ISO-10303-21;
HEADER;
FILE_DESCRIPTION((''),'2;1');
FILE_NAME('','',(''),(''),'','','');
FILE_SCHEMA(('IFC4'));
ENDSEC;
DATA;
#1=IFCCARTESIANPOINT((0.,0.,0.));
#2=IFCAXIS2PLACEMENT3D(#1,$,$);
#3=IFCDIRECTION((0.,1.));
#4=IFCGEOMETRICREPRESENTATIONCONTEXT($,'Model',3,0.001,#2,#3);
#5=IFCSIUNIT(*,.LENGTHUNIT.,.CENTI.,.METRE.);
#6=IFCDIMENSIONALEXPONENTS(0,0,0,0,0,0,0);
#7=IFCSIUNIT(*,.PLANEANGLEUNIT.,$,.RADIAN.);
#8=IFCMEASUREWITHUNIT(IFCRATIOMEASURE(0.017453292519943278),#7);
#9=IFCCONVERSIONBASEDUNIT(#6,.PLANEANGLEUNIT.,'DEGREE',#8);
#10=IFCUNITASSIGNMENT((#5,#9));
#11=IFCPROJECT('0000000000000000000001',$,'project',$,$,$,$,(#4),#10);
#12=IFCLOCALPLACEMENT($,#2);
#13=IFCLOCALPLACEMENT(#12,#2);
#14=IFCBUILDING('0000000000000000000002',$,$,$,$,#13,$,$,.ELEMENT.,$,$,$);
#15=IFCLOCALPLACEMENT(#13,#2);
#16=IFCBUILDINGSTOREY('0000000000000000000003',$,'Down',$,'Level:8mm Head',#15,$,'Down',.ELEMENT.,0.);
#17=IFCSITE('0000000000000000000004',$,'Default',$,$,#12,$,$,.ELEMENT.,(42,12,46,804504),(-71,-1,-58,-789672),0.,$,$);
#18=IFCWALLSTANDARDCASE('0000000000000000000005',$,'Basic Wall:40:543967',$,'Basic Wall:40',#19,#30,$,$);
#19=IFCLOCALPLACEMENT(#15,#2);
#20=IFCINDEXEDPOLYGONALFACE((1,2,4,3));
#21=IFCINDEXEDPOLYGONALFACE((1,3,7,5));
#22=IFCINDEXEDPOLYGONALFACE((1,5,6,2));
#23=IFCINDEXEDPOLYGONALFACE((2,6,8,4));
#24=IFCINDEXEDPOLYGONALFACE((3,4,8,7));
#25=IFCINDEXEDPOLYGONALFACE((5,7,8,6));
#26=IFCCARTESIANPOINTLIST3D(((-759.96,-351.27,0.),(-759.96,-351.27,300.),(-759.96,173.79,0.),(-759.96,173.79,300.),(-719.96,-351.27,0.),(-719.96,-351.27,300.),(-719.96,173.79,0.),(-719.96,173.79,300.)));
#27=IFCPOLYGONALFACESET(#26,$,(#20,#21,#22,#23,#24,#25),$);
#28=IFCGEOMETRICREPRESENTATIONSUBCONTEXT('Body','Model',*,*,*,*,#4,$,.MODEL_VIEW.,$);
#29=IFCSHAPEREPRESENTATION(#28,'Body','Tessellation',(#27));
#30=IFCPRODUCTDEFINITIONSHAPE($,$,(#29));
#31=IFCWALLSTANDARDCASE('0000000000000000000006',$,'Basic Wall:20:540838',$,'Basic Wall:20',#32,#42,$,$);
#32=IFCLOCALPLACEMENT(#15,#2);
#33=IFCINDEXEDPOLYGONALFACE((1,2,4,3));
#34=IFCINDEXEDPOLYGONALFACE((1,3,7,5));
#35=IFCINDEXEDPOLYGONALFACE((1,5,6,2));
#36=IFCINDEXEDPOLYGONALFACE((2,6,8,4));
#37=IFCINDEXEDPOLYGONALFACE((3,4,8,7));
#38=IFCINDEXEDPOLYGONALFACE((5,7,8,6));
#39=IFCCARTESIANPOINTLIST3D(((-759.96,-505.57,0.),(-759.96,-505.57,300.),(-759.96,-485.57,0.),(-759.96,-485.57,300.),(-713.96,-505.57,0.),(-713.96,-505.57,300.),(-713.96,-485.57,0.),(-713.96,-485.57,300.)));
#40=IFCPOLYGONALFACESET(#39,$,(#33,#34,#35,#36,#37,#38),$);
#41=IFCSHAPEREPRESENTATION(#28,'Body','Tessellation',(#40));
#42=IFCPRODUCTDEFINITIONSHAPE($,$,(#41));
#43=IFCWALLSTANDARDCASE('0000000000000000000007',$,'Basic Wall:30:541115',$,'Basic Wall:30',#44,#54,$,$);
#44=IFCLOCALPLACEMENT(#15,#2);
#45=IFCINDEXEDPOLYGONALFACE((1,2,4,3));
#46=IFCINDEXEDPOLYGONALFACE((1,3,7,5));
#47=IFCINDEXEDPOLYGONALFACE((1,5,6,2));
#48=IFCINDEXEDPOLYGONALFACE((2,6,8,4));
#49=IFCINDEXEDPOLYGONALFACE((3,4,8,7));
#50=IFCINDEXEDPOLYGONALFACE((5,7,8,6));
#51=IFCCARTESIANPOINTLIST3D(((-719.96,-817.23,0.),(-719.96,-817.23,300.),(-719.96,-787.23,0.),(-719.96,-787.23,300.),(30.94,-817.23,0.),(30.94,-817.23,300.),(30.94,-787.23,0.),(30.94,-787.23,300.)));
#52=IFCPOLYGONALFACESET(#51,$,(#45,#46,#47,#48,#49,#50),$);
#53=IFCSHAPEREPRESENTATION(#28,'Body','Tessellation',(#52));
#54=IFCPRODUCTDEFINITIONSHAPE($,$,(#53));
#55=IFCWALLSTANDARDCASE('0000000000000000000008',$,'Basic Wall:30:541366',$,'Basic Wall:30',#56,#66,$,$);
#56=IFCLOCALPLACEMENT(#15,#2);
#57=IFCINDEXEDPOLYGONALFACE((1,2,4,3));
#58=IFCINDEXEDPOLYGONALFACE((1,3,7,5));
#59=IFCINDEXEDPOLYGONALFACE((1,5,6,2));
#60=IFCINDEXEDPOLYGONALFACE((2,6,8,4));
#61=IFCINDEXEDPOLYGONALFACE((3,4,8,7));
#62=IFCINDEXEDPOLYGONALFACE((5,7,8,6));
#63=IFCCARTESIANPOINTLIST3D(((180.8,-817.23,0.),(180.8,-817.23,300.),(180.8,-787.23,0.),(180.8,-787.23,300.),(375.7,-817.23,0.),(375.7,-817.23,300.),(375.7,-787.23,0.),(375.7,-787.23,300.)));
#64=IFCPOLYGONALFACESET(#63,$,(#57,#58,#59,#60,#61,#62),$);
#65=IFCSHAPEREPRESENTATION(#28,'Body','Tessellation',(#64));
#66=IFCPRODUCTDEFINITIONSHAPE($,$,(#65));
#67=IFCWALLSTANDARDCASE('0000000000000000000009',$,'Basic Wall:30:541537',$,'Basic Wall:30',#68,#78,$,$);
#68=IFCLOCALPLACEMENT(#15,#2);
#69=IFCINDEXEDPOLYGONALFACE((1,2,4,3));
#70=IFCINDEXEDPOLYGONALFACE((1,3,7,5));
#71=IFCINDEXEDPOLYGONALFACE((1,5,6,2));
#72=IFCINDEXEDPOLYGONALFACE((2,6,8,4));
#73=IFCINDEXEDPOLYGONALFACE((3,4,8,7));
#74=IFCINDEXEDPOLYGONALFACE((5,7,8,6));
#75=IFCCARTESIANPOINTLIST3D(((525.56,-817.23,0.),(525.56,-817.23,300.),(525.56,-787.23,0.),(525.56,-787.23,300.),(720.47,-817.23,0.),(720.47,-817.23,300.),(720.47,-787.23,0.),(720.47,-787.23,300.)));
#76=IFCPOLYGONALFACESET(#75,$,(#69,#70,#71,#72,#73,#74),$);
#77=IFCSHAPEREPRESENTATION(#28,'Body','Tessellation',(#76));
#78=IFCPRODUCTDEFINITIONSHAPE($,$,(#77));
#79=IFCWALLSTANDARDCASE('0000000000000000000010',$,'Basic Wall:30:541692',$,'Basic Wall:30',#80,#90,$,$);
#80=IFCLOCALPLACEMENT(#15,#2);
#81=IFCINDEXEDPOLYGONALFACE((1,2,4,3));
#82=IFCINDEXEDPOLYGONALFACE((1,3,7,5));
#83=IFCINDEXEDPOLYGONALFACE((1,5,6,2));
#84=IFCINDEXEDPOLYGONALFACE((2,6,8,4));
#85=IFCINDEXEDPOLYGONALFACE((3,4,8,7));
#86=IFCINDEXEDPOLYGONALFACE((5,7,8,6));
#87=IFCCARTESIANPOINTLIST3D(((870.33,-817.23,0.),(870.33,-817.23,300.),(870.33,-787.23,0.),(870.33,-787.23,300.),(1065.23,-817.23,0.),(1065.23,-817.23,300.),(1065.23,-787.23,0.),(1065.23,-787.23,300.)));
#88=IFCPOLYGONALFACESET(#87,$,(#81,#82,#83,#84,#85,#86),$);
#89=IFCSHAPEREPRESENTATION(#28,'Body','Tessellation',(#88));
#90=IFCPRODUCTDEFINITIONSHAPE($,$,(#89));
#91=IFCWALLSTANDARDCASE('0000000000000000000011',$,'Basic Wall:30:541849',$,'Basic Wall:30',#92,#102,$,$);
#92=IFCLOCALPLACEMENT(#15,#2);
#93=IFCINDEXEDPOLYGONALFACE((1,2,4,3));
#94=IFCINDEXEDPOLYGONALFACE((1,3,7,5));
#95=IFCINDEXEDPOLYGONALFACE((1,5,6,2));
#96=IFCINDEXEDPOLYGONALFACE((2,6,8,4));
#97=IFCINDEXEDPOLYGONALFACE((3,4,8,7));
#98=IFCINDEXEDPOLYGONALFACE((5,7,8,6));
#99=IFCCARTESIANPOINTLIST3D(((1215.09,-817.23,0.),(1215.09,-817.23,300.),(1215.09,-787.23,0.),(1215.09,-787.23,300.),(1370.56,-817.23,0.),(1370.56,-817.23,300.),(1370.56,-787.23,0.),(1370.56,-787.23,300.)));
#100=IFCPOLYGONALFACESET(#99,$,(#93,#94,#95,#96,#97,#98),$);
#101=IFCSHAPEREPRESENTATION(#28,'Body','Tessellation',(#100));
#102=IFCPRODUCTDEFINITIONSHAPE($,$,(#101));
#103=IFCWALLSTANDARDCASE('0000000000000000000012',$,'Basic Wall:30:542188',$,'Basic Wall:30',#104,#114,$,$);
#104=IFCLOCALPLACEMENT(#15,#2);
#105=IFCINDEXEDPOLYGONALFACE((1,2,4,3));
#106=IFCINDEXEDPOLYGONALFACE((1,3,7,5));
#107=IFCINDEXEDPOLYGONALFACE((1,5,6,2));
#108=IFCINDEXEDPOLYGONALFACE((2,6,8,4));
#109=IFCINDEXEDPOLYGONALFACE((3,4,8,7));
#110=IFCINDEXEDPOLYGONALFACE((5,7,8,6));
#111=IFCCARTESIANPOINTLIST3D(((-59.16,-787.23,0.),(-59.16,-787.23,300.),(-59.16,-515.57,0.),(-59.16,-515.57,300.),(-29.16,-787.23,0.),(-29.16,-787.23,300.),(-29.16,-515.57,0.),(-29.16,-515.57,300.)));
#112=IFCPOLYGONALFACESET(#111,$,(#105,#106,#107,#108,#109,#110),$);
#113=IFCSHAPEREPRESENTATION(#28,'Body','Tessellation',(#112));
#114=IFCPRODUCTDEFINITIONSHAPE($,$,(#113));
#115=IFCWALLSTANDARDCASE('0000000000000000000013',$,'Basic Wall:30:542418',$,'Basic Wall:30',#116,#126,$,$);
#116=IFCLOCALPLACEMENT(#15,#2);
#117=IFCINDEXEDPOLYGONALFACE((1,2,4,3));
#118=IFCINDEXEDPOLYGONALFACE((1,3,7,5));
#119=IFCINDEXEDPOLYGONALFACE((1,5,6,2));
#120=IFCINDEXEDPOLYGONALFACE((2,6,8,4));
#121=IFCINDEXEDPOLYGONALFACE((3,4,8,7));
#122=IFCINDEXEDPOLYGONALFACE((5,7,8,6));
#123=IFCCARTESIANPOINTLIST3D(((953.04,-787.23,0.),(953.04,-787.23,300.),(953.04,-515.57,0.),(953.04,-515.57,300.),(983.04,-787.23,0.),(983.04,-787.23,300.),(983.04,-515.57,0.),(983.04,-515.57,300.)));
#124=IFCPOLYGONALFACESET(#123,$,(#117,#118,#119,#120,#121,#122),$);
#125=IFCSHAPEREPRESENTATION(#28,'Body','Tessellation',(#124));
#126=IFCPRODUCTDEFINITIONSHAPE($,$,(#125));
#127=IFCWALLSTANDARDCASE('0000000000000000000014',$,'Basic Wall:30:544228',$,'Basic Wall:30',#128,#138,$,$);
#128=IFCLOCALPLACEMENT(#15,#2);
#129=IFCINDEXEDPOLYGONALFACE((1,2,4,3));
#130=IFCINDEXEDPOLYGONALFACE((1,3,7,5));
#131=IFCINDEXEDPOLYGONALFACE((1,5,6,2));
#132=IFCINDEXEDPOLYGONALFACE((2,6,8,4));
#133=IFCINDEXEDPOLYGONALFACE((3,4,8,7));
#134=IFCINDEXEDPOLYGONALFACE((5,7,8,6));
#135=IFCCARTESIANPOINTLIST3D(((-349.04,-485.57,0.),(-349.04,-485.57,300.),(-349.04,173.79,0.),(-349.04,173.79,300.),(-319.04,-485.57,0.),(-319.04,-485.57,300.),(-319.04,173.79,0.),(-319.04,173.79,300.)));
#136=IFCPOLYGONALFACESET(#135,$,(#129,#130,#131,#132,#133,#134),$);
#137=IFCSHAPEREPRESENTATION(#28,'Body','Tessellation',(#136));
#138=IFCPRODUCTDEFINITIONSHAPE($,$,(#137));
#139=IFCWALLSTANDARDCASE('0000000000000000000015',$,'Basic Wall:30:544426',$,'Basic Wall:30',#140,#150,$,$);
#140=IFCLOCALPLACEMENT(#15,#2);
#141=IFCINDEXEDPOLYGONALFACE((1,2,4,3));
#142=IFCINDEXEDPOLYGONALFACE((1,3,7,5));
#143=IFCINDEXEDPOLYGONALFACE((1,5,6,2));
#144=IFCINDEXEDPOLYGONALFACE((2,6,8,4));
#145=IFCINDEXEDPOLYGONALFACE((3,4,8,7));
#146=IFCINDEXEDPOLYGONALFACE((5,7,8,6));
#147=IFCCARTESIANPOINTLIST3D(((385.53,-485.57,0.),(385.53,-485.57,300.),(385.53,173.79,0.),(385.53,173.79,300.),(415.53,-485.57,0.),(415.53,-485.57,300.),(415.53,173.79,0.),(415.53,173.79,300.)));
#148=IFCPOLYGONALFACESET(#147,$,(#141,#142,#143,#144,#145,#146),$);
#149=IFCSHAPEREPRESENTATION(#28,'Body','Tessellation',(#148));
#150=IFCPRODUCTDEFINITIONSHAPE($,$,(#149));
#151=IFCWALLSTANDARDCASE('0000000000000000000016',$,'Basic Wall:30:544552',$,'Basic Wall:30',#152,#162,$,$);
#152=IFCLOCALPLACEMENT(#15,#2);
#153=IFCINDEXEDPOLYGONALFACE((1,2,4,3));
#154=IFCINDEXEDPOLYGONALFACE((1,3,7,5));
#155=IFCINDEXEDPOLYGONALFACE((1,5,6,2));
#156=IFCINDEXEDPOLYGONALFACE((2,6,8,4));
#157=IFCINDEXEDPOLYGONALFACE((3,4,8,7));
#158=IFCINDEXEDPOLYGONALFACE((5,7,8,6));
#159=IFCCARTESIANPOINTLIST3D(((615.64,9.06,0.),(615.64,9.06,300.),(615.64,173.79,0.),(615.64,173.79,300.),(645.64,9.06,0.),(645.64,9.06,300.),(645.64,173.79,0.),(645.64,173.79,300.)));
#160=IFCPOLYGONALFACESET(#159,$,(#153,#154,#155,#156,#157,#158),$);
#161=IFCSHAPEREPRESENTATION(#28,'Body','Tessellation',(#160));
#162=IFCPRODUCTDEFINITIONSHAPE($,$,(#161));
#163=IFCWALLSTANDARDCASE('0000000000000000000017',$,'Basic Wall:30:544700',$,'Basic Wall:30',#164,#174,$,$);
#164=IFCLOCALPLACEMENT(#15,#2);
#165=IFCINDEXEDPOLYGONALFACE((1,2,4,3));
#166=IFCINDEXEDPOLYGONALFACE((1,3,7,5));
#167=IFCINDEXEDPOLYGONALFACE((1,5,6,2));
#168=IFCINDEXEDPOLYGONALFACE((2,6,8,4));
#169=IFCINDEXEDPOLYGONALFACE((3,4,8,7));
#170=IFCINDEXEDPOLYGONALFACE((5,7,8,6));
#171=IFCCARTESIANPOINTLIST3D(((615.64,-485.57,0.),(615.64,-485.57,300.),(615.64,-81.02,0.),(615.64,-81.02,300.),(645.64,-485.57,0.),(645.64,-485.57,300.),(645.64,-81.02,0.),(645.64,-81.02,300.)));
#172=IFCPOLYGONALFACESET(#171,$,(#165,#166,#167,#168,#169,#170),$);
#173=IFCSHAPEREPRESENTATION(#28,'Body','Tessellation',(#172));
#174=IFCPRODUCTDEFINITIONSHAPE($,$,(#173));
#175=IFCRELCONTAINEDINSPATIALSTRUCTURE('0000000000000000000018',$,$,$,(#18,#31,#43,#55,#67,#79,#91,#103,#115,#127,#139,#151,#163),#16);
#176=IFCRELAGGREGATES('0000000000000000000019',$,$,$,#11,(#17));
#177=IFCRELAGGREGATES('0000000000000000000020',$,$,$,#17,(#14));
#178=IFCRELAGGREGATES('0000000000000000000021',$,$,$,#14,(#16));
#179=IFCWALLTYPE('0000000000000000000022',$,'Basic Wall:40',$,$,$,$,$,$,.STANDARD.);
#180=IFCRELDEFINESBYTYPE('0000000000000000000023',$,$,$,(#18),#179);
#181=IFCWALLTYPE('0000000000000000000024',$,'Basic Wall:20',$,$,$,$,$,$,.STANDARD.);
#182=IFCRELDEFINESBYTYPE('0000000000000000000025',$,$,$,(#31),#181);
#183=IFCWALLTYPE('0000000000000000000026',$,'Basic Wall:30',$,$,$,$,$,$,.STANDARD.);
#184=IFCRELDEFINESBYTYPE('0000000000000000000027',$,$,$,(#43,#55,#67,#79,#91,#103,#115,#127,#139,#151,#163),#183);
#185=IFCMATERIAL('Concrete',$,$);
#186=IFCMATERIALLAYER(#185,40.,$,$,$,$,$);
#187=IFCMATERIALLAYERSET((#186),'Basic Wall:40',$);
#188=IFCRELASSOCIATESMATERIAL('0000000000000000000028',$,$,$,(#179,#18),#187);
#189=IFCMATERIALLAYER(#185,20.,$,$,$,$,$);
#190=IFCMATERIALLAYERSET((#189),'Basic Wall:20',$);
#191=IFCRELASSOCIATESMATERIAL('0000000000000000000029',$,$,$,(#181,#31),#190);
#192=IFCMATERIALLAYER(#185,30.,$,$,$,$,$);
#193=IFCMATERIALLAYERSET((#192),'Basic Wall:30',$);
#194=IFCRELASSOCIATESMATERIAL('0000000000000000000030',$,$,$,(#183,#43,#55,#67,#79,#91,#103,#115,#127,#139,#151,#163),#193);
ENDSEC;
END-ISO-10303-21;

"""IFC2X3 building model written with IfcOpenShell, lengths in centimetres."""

from ifc_helpers import new_model, entity, si_unit, converted_unit, direction, frame, frame_2d, origin, place, context, subcontext, project, spatial, rectangle, extrude, material, layer, layer_set, layer_usage, type_object, element, save


model = new_model("IFC2X3")

# Units and contexts
model_context = context("Model", 3, precision=0.001, world=origin(), true_north=direction((0.0, 1.0)))
body_context = subcontext(model_context, "Body", "Model", "MODEL_VIEW")
ifc_project = project(units=[si_unit("LENGTHUNIT", "METRE", prefix="CENTI"), converted_unit("PLANEANGLEUNIT", "DEGREE", entity("IfcRatioMeasure", 0.017453292519943278), si_unit("PLANEANGLEUNIT", "RADIAN"), dimensions=[0, 0, 0, 0, 0, 0, 0])], contexts=[model_context])

# Site, building, storey
site_placement = place(None, origin())
site = spatial("IfcSite", under=ifc_project, at=site_placement, Name="Default", CompositionType="ELEMENT", RefLatitude=(42, 12, 46, 804504), RefLongitude=(-71, -1, -58, -789672), RefElevation=0.0)
building_placement = place(site_placement, origin())
building = spatial("IfcBuilding", under=site, at=building_placement, CompositionType="ELEMENT")
storey_placement = place(building_placement, origin())
storey = spatial("IfcBuildingStorey", under=building, at=storey_placement, Name="Down", ObjectType="Level:8mm Head", LongName="Down", CompositionType="ELEMENT", Elevation=0.0)

# Shared definitions
ifc_material = material(Name="Concrete")

# Walls
ifc_layer_1 = layer(ifc_material, 40.0)
ifc_layer_set_1 = layer_set([ifc_layer_1], Name="Basic Wall:40")
wall_type_1 = type_object("IfcWallType", Name="Basic Wall:40", PredefinedType="STANDARD", material=ifc_layer_set_1)
ifc_layer_usage_1 = layer_usage(ifc_layer_set_1, "AXIS2", "POSITIVE", -20.0)
wall_1_placement = place(storey_placement, frame((-739.96, 173.79, 0.0), z_axis=(0.0, 0.0, 1.0), x_axis=(0.0, -1.0, 0.0)))
element("IfcWallStandardCase", 1, at=wall_1_placement, inside=storey, type_object=wall_type_1, material=ifc_layer_usage_1, Name="Basic Wall:40:543967", ObjectType="Basic Wall:40", context=body_context, shape_type="SweptSolid", body=[
    extrude(rectangle(XDim=525.05, YDim=40.0, at=frame_2d((262.53, 0.0), x_axis=(-1.0, 0.0))), origin(), (0.0, 0.0, 1.0), 300.0),
])
ifc_layer_2 = layer(ifc_material, 20.0)
ifc_layer_set_2 = layer_set([ifc_layer_2], Name="Basic Wall:20")
ifc_layer_usage_2 = layer_usage(ifc_layer_set_2, "AXIS2", "NEGATIVE", 10.0)
wall_type_2 = type_object("IfcWallType", Name="Basic Wall:20", PredefinedType="STANDARD", material=ifc_layer_set_2)
wall_2_placement = place(storey_placement, frame((-759.96, -495.57, 0.0)))
element("IfcWallStandardCase", 2, at=wall_2_placement, inside=storey, type_object=wall_type_2, material=ifc_layer_usage_2, Name="Basic Wall:20:540838", ObjectType="Basic Wall:20", context=body_context, shape_type="SweptSolid", body=[
    extrude(rectangle(XDim=46.0, YDim=20.0, at=frame_2d((23.0, 0.0), x_axis=(-1.0, 0.0))), origin(), (0.0, 0.0, 1.0), 300.0),
])
ifc_layer_3 = layer(ifc_material, 30.0)
ifc_layer_set_3 = layer_set([ifc_layer_3], Name="Basic Wall:30")
ifc_layer_usage_3 = layer_usage(ifc_layer_set_3, "AXIS2", "POSITIVE", -15.0)
wall_type_3 = type_object("IfcWallType", Name="Basic Wall:30", PredefinedType="STANDARD", material=ifc_layer_set_3)
wall_3_placement = place(storey_placement, frame((-719.96, -802.23, 0.0)))
element("IfcWallStandardCase", 3, at=wall_3_placement, inside=storey, type_object=wall_type_3, material=ifc_layer_usage_3, Name="Basic Wall:30:541115", ObjectType="Basic Wall:30", context=body_context, shape_type="SweptSolid", body=[
    extrude(rectangle(XDim=750.9, YDim=30.0, at=frame_2d((375.45, 0.0), x_axis=(-1.0, 0.0))), origin(), (0.0, 0.0, 1.0), 300.0),
])
ifc_layer_usage_4 = layer_usage(ifc_layer_set_3, "AXIS2", "POSITIVE", -15.0)
wall_4_placement = place(storey_placement, frame((180.8, -802.23, 0.0)))
element("IfcWallStandardCase", 4, at=wall_4_placement, inside=storey, type_object=wall_type_3, material=ifc_layer_usage_4, Name="Basic Wall:30:541366", ObjectType="Basic Wall:30", context=body_context, shape_type="SweptSolid", body=[
    extrude(rectangle(XDim=194.9, YDim=30.0, at=frame_2d((97.45, 0.0), x_axis=(-1.0, 0.0))), origin(), (0.0, 0.0, 1.0), 300.0),
])
ifc_layer_usage_5 = layer_usage(ifc_layer_set_3, "AXIS2", "POSITIVE", -15.0)
wall_5_placement = place(storey_placement, frame((525.56, -802.23, 0.0)))
element("IfcWallStandardCase", 5, at=wall_5_placement, inside=storey, type_object=wall_type_3, material=ifc_layer_usage_5, Name="Basic Wall:30:541537", ObjectType="Basic Wall:30", context=body_context, shape_type="SweptSolid", body=[
    extrude(rectangle(XDim=194.9, YDim=30.0, at=frame_2d((97.45, 0.0), x_axis=(-1.0, 0.0))), origin(), (0.0, 0.0, 1.0), 300.0),
])
ifc_layer_usage_6 = layer_usage(ifc_layer_set_3, "AXIS2", "POSITIVE", -15.0)
wall_6_placement = place(storey_placement, frame((870.33, -802.23, 0.0)))
element("IfcWallStandardCase", 6, at=wall_6_placement, inside=storey, type_object=wall_type_3, material=ifc_layer_usage_6, Name="Basic Wall:30:541692", ObjectType="Basic Wall:30", context=body_context, shape_type="SweptSolid", body=[
    extrude(rectangle(XDim=194.9, YDim=30.0, at=frame_2d((97.45, 0.0), x_axis=(-1.0, 0.0))), origin(), (0.0, 0.0, 1.0), 300.0),
])
ifc_layer_usage_7 = layer_usage(ifc_layer_set_3, "AXIS2", "POSITIVE", -15.0)
wall_7_placement = place(storey_placement, frame((1215.09, -802.23, 0.0)))
element("IfcWallStandardCase", 7, at=wall_7_placement, inside=storey, type_object=wall_type_3, material=ifc_layer_usage_7, Name="Basic Wall:30:541849", ObjectType="Basic Wall:30", context=body_context, shape_type="SweptSolid", body=[
    extrude(rectangle(XDim=155.47, YDim=30.0, at=frame_2d((77.73, 0.0), x_axis=(-1.0, 0.0))), origin(), (0.0, 0.0, 1.0), 300.0),
])
ifc_layer_usage_8 = layer_usage(ifc_layer_set_3, "AXIS2", "POSITIVE", -15.0)
wall_8_placement = place(storey_placement, frame((-44.16, -787.23, 0.0), z_axis=(0.0, 0.0, 1.0), x_axis=(0.0, 1.0, 0.0)))
element("IfcWallStandardCase", 8, at=wall_8_placement, inside=storey, type_object=wall_type_3, material=ifc_layer_usage_8, Name="Basic Wall:30:542188", ObjectType="Basic Wall:30", context=body_context, shape_type="SweptSolid", body=[
    extrude(rectangle(XDim=271.66, YDim=30.0, at=frame_2d((135.83, 0.0), x_axis=(-1.0, 0.0))), origin(), (0.0, 0.0, 1.0), 300.0),
])
ifc_layer_usage_9 = layer_usage(ifc_layer_set_3, "AXIS2", "NEGATIVE", 15.0)
wall_9_placement = place(storey_placement, frame((968.04, -787.23, 0.0), z_axis=(0.0, 0.0, 1.0), x_axis=(0.0, 1.0, 0.0)))
element("IfcWallStandardCase", 9, at=wall_9_placement, inside=storey, type_object=wall_type_3, material=ifc_layer_usage_9, Name="Basic Wall:30:542418", ObjectType="Basic Wall:30", context=body_context, shape_type="SweptSolid", body=[
    extrude(rectangle(XDim=271.66, YDim=30.0, at=frame_2d((135.83, 0.0), x_axis=(-1.0, 0.0))), origin(), (0.0, 0.0, 1.0), 300.0),
])
ifc_layer_usage_10 = layer_usage(ifc_layer_set_3, "AXIS2", "NEGATIVE", 15.0)
wall_10_placement = place(storey_placement, frame((-334.04, -485.57, 0.0), z_axis=(0.0, 0.0, 1.0), x_axis=(0.0, 1.0, 0.0)))
element("IfcWallStandardCase", 10, at=wall_10_placement, inside=storey, type_object=wall_type_3, material=ifc_layer_usage_10, Name="Basic Wall:30:544228", ObjectType="Basic Wall:30", context=body_context, shape_type="SweptSolid", body=[
    extrude(rectangle(XDim=659.35, YDim=30.0, at=frame_2d((329.68, 0.0), x_axis=(-1.0, 0.0))), origin(), (0.0, 0.0, 1.0), 300.0),
])
ifc_layer_usage_11 = layer_usage(ifc_layer_set_3, "AXIS2", "NEGATIVE", 15.0)
wall_11_placement = place(storey_placement, frame((400.53, -485.57, 0.0), z_axis=(0.0, 0.0, 1.0), x_axis=(0.0, 1.0, 0.0)))
element("IfcWallStandardCase", 11, at=wall_11_placement, inside=storey, type_object=wall_type_3, material=ifc_layer_usage_11, Name="Basic Wall:30:544426", ObjectType="Basic Wall:30", context=body_context, shape_type="SweptSolid", body=[
    extrude(rectangle(XDim=659.35, YDim=30.0, at=frame_2d((329.68, 0.0), x_axis=(-1.0, 0.0))), origin(), (0.0, 0.0, 1.0), 300.0),
])
ifc_layer_usage_12 = layer_usage(ifc_layer_set_3, "AXIS2", "NEGATIVE", 15.0)
wall_12_placement = place(storey_placement, frame((630.64, 9.06, 0.0), z_axis=(0.0, 0.0, 1.0), x_axis=(0.0, 1.0, 0.0)))
element("IfcWallStandardCase", 12, at=wall_12_placement, inside=storey, type_object=wall_type_3, material=ifc_layer_usage_12, Name="Basic Wall:30:544552", ObjectType="Basic Wall:30", context=body_context, shape_type="SweptSolid", body=[
    extrude(rectangle(XDim=164.73, YDim=30.0, at=frame_2d((82.36, 0.0), x_axis=(-1.0, 0.0))), origin(), (0.0, 0.0, 1.0), 300.0),
])
ifc_layer_usage_13 = layer_usage(ifc_layer_set_3, "AXIS2", "POSITIVE", -15.0)
wall_13_placement = place(storey_placement, frame((630.64, -81.02, 0.0), z_axis=(0.0, 0.0, 1.0), x_axis=(0.0, -1.0, 0.0)))
element("IfcWallStandardCase", 13, at=wall_13_placement, inside=storey, type_object=wall_type_3, material=ifc_layer_usage_13, Name="Basic Wall:30:544700", ObjectType="Basic Wall:30", context=body_context, shape_type="SweptSolid", body=[
    extrude(rectangle(XDim=404.54, YDim=30.0, at=frame_2d((202.27, 0.0), x_axis=(-1.0, 0.0))), origin(), (0.0, 0.0, 1.0), 300.0),
])

save(model, "model.ifc")
